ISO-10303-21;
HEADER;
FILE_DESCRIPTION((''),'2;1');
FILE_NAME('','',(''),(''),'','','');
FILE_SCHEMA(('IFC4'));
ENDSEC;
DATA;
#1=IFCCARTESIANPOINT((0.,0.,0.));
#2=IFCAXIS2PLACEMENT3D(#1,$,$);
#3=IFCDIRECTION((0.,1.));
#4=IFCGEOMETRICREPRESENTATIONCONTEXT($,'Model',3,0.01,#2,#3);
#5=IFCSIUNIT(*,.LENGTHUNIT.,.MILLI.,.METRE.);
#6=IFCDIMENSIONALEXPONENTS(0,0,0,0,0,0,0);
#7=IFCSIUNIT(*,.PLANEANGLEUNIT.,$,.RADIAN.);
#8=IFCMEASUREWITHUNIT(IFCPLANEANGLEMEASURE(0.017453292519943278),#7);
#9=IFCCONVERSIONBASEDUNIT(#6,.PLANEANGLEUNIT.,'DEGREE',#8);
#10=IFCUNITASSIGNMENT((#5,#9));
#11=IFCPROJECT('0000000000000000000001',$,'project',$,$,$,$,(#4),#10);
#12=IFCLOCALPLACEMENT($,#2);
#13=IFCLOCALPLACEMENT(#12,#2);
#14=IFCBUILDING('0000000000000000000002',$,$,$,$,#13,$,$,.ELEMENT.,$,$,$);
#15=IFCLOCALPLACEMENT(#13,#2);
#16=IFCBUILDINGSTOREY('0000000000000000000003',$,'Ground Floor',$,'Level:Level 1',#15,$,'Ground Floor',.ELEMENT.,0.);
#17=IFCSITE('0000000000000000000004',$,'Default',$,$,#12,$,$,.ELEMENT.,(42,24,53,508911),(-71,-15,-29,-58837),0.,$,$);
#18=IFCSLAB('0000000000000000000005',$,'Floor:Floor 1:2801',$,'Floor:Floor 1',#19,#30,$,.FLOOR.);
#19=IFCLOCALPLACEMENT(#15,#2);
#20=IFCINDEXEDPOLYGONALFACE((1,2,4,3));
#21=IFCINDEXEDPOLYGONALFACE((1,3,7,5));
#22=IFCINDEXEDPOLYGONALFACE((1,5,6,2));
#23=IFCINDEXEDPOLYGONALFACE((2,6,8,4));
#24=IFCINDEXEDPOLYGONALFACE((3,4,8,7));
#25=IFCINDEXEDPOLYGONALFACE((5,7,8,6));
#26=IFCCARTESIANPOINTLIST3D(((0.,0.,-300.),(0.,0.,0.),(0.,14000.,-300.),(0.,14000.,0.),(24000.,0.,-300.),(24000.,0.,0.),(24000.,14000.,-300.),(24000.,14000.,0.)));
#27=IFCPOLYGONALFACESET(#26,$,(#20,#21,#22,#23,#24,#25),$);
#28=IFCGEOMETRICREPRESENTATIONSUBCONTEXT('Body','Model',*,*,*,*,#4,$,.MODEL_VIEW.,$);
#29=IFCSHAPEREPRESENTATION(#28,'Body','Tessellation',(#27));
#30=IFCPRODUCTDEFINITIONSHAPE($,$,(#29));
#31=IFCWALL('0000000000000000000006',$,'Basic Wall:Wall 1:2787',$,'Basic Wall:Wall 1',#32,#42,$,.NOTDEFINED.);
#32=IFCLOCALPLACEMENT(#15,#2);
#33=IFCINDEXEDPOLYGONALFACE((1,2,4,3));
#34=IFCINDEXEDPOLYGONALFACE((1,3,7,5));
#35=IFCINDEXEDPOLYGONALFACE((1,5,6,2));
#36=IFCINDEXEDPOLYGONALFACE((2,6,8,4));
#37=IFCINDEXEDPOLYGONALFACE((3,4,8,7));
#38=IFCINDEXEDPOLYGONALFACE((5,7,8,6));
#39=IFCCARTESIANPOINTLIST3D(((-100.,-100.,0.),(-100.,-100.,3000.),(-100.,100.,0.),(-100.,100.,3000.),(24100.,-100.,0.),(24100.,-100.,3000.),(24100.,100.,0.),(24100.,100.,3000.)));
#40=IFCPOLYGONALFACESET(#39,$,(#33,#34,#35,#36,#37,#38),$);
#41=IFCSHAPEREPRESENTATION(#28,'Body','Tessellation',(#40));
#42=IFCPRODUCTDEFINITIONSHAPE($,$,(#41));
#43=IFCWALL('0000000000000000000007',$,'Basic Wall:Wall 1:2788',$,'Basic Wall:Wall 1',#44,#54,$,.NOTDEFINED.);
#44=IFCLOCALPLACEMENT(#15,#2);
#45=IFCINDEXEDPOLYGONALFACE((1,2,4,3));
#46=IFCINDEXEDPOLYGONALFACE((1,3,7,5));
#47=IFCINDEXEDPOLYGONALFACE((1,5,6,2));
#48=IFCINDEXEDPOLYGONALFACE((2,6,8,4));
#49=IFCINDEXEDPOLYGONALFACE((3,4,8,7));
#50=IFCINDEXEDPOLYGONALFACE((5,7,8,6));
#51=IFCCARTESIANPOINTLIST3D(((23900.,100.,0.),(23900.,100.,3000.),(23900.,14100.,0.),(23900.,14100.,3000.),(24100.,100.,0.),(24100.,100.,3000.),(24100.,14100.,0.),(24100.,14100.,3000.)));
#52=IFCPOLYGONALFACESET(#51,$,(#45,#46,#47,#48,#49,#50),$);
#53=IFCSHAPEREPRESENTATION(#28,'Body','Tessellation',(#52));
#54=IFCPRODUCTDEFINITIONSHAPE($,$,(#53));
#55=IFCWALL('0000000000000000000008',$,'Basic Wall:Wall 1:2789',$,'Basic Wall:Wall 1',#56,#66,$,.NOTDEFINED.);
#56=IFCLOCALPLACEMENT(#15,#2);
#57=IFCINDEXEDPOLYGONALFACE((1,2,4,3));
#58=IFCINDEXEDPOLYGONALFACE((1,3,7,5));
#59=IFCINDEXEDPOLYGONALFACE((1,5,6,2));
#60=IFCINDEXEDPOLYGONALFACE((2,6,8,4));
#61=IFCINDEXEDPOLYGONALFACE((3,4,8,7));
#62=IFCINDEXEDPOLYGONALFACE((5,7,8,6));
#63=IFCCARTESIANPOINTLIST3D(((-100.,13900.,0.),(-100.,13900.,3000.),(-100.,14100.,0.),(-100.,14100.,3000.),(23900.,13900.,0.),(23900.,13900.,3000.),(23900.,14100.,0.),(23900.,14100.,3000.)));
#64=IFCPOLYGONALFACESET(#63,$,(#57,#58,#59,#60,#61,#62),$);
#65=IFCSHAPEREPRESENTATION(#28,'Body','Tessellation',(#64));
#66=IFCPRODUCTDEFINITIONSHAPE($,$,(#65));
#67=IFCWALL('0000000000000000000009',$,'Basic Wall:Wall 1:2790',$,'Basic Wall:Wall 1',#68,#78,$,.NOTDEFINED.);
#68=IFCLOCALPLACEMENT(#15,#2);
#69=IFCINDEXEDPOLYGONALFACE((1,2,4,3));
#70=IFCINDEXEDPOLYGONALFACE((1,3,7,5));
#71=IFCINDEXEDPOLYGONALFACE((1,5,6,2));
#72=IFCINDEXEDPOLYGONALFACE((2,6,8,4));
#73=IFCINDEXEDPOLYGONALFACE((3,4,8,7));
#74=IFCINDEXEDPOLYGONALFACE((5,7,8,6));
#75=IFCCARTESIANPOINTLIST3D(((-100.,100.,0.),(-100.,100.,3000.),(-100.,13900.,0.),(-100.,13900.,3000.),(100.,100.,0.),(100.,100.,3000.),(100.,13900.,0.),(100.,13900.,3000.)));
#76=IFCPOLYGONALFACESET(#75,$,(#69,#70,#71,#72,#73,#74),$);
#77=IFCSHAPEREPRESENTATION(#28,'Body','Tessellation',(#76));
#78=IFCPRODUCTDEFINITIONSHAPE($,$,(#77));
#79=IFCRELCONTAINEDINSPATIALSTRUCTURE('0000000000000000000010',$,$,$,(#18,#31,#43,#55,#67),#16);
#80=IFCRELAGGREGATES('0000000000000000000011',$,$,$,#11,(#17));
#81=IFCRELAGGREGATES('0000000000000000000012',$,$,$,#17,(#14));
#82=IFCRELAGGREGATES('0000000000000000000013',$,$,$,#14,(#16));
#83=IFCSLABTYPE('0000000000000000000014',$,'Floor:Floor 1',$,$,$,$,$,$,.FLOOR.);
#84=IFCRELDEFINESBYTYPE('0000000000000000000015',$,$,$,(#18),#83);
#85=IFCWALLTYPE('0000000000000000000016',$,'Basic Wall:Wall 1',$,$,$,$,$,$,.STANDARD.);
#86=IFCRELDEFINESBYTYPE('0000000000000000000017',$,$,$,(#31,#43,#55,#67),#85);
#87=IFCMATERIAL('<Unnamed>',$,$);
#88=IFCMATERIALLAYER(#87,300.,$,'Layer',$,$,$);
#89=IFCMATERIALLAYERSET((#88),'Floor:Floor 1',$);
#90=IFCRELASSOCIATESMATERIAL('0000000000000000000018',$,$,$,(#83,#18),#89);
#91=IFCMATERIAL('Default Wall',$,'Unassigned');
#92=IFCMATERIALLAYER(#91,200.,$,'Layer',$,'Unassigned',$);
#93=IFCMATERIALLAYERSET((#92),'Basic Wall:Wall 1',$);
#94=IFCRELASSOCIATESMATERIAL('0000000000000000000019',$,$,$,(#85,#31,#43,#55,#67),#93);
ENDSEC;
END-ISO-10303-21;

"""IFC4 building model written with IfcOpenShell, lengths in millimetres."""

from ifc_helpers import new_model, entity, si_unit, converted_unit, direction, frame, frame_2d, origin, origin_2d_with_axis, place, context, subcontext, project, spatial, rectangle, extrude, material, layer, layer_set, layer_usage, type_object, element, save


model = new_model("IFC4")

# Units and contexts
model_context = context("Model", 3, precision=0.01, world=origin(), true_north=direction((0.0, 1.0)))
body_context = subcontext(model_context, "Body", "Model", "MODEL_VIEW")
ifc_project = project(units=[si_unit("LENGTHUNIT", "METRE", prefix="MILLI"), converted_unit("PLANEANGLEUNIT", "DEGREE", entity("IfcPlaneAngleMeasure", 0.017453292519943278), si_unit("PLANEANGLEUNIT", "RADIAN"), dimensions=[0, 0, 0, 0, 0, 0, 0])], contexts=[model_context])

# Site, building, storey
site_placement = place(None, origin())
site = spatial("IfcSite", under=ifc_project, at=site_placement, Name="Default", CompositionType="ELEMENT", RefLatitude=(42, 24, 53, 508911), RefLongitude=(-71, -15, -29, -58837), RefElevation=0.0)
building_placement = place(site_placement, origin())
building = spatial("IfcBuilding", under=site, at=building_placement, CompositionType="ELEMENT")
storey_placement = place(building_placement, origin())
storey = spatial("IfcBuildingStorey", under=building, at=storey_placement, Name="Ground Floor", ObjectType="Level:Level 1", LongName="Ground Floor", CompositionType="ELEMENT", Elevation=0.0)

# Shared definitions
ifc_material_1 = material(Name="Default Wall", Category="Unassigned")

# Slab
ifc_material_2 = material(Name="<Unnamed>")
ifc_layer_1 = layer(ifc_material_2, 300.0, Name="Layer")
ifc_layer_set_1 = layer_set([ifc_layer_1], Name="Floor:Floor 1")
ifc_layer_usage_1 = layer_usage(ifc_layer_set_1, "AXIS3", "POSITIVE", 0.0)
slab_type = type_object("IfcSlabType", Name="Floor:Floor 1", PredefinedType="FLOOR", material=ifc_layer_set_1)
slab_placement = place(storey_placement, origin())
element("IfcSlab", 1, at=slab_placement, inside=storey, type_object=slab_type, material=ifc_layer_usage_1, Name="Floor:Floor 1:2801", ObjectType="Floor:Floor 1", PredefinedType="FLOOR", context=body_context, shape_type="SweptSolid", body=[
    extrude(rectangle(XDim=14000.0, YDim=24000.0, at=origin_2d_with_axis()), frame((12000.0, 7000.0, 0.0), z_axis=(0.0, 0.0, -1.0), x_axis=(0.0, 1.0, 0.0)), (0.0, 0.0, 1.0), 300.0),
])

# Walls
ifc_layer_2 = layer(ifc_material_1, 200.0, Name="Layer", Category="Unassigned")
ifc_layer_set_2 = layer_set([ifc_layer_2], Name="Basic Wall:Wall 1")
ifc_layer_usage_2 = layer_usage(ifc_layer_set_2, "AXIS2", "NEGATIVE", 100.0)
wall_type = type_object("IfcWallType", Name="Basic Wall:Wall 1", PredefinedType="STANDARD", material=ifc_layer_set_2)
wall_1_placement = place(storey_placement, frame((-100.0, 0.0, 0.0)))
element("IfcWall", 2, at=wall_1_placement, inside=storey, type_object=wall_type, material=ifc_layer_usage_2, Name="Basic Wall:Wall 1:2787", ObjectType="Basic Wall:Wall 1", PredefinedType="NOTDEFINED", context=body_context, shape_type="SweptSolid", body=[
    extrude(rectangle(XDim=24200.0, YDim=200.0, at=frame_2d((12100.0, 0.0), x_axis=(-1.0, 0.0))), origin(), (0.0, 0.0, 1.0), 3000.0),
])
ifc_layer_usage_3 = layer_usage(ifc_layer_set_2, "AXIS2", "NEGATIVE", 100.0)
wall_2_placement = place(storey_placement, frame((24000.0, 100.0, 0.0), z_axis=(0.0, 0.0, 1.0), x_axis=(0.0, 1.0, 0.0)))
element("IfcWall", 3, at=wall_2_placement, inside=storey, type_object=wall_type, material=ifc_layer_usage_3, Name="Basic Wall:Wall 1:2788", ObjectType="Basic Wall:Wall 1", PredefinedType="NOTDEFINED", context=body_context, shape_type="SweptSolid", body=[
    extrude(rectangle(XDim=14000.0, YDim=200.0, at=frame_2d((7000.0, 0.0), x_axis=(-1.0, 0.0))), origin(), (0.0, 0.0, 1.0), 3000.0),
])
ifc_layer_usage_4 = layer_usage(ifc_layer_set_2, "AXIS2", "NEGATIVE", 100.0)
wall_3_placement = place(storey_placement, frame((23900.0, 14000.0, 0.0), z_axis=(0.0, 0.0, 1.0), x_axis=(-1.0, 0.0, 0.0)))
element("IfcWall", 4, at=wall_3_placement, inside=storey, type_object=wall_type, material=ifc_layer_usage_4, Name="Basic Wall:Wall 1:2789", ObjectType="Basic Wall:Wall 1", PredefinedType="NOTDEFINED", context=body_context, shape_type="SweptSolid", body=[
    extrude(rectangle(XDim=24000.0, YDim=200.0, at=frame_2d((12000.0, 0.0), x_axis=(-1.0, 0.0))), origin(), (0.0, 0.0, 1.0), 3000.0),
])
ifc_layer_usage_5 = layer_usage(ifc_layer_set_2, "AXIS2", "NEGATIVE", 100.0)
wall_4_placement = place(storey_placement, frame((0.0, 13900.0, 0.0), z_axis=(0.0, 0.0, 1.0), x_axis=(0.0, -1.0, 0.0)))
element("IfcWall", 5, at=wall_4_placement, inside=storey, type_object=wall_type, material=ifc_layer_usage_5, Name="Basic Wall:Wall 1:2790", ObjectType="Basic Wall:Wall 1", PredefinedType="NOTDEFINED", context=body_context, shape_type="SweptSolid", body=[
    extrude(rectangle(XDim=13800.0, YDim=200.0, at=frame_2d((6900.0, 0.0), x_axis=(-1.0, 0.0))), origin(), (0.0, 0.0, 1.0), 3000.0),
])

save(model, "model.ifc")
